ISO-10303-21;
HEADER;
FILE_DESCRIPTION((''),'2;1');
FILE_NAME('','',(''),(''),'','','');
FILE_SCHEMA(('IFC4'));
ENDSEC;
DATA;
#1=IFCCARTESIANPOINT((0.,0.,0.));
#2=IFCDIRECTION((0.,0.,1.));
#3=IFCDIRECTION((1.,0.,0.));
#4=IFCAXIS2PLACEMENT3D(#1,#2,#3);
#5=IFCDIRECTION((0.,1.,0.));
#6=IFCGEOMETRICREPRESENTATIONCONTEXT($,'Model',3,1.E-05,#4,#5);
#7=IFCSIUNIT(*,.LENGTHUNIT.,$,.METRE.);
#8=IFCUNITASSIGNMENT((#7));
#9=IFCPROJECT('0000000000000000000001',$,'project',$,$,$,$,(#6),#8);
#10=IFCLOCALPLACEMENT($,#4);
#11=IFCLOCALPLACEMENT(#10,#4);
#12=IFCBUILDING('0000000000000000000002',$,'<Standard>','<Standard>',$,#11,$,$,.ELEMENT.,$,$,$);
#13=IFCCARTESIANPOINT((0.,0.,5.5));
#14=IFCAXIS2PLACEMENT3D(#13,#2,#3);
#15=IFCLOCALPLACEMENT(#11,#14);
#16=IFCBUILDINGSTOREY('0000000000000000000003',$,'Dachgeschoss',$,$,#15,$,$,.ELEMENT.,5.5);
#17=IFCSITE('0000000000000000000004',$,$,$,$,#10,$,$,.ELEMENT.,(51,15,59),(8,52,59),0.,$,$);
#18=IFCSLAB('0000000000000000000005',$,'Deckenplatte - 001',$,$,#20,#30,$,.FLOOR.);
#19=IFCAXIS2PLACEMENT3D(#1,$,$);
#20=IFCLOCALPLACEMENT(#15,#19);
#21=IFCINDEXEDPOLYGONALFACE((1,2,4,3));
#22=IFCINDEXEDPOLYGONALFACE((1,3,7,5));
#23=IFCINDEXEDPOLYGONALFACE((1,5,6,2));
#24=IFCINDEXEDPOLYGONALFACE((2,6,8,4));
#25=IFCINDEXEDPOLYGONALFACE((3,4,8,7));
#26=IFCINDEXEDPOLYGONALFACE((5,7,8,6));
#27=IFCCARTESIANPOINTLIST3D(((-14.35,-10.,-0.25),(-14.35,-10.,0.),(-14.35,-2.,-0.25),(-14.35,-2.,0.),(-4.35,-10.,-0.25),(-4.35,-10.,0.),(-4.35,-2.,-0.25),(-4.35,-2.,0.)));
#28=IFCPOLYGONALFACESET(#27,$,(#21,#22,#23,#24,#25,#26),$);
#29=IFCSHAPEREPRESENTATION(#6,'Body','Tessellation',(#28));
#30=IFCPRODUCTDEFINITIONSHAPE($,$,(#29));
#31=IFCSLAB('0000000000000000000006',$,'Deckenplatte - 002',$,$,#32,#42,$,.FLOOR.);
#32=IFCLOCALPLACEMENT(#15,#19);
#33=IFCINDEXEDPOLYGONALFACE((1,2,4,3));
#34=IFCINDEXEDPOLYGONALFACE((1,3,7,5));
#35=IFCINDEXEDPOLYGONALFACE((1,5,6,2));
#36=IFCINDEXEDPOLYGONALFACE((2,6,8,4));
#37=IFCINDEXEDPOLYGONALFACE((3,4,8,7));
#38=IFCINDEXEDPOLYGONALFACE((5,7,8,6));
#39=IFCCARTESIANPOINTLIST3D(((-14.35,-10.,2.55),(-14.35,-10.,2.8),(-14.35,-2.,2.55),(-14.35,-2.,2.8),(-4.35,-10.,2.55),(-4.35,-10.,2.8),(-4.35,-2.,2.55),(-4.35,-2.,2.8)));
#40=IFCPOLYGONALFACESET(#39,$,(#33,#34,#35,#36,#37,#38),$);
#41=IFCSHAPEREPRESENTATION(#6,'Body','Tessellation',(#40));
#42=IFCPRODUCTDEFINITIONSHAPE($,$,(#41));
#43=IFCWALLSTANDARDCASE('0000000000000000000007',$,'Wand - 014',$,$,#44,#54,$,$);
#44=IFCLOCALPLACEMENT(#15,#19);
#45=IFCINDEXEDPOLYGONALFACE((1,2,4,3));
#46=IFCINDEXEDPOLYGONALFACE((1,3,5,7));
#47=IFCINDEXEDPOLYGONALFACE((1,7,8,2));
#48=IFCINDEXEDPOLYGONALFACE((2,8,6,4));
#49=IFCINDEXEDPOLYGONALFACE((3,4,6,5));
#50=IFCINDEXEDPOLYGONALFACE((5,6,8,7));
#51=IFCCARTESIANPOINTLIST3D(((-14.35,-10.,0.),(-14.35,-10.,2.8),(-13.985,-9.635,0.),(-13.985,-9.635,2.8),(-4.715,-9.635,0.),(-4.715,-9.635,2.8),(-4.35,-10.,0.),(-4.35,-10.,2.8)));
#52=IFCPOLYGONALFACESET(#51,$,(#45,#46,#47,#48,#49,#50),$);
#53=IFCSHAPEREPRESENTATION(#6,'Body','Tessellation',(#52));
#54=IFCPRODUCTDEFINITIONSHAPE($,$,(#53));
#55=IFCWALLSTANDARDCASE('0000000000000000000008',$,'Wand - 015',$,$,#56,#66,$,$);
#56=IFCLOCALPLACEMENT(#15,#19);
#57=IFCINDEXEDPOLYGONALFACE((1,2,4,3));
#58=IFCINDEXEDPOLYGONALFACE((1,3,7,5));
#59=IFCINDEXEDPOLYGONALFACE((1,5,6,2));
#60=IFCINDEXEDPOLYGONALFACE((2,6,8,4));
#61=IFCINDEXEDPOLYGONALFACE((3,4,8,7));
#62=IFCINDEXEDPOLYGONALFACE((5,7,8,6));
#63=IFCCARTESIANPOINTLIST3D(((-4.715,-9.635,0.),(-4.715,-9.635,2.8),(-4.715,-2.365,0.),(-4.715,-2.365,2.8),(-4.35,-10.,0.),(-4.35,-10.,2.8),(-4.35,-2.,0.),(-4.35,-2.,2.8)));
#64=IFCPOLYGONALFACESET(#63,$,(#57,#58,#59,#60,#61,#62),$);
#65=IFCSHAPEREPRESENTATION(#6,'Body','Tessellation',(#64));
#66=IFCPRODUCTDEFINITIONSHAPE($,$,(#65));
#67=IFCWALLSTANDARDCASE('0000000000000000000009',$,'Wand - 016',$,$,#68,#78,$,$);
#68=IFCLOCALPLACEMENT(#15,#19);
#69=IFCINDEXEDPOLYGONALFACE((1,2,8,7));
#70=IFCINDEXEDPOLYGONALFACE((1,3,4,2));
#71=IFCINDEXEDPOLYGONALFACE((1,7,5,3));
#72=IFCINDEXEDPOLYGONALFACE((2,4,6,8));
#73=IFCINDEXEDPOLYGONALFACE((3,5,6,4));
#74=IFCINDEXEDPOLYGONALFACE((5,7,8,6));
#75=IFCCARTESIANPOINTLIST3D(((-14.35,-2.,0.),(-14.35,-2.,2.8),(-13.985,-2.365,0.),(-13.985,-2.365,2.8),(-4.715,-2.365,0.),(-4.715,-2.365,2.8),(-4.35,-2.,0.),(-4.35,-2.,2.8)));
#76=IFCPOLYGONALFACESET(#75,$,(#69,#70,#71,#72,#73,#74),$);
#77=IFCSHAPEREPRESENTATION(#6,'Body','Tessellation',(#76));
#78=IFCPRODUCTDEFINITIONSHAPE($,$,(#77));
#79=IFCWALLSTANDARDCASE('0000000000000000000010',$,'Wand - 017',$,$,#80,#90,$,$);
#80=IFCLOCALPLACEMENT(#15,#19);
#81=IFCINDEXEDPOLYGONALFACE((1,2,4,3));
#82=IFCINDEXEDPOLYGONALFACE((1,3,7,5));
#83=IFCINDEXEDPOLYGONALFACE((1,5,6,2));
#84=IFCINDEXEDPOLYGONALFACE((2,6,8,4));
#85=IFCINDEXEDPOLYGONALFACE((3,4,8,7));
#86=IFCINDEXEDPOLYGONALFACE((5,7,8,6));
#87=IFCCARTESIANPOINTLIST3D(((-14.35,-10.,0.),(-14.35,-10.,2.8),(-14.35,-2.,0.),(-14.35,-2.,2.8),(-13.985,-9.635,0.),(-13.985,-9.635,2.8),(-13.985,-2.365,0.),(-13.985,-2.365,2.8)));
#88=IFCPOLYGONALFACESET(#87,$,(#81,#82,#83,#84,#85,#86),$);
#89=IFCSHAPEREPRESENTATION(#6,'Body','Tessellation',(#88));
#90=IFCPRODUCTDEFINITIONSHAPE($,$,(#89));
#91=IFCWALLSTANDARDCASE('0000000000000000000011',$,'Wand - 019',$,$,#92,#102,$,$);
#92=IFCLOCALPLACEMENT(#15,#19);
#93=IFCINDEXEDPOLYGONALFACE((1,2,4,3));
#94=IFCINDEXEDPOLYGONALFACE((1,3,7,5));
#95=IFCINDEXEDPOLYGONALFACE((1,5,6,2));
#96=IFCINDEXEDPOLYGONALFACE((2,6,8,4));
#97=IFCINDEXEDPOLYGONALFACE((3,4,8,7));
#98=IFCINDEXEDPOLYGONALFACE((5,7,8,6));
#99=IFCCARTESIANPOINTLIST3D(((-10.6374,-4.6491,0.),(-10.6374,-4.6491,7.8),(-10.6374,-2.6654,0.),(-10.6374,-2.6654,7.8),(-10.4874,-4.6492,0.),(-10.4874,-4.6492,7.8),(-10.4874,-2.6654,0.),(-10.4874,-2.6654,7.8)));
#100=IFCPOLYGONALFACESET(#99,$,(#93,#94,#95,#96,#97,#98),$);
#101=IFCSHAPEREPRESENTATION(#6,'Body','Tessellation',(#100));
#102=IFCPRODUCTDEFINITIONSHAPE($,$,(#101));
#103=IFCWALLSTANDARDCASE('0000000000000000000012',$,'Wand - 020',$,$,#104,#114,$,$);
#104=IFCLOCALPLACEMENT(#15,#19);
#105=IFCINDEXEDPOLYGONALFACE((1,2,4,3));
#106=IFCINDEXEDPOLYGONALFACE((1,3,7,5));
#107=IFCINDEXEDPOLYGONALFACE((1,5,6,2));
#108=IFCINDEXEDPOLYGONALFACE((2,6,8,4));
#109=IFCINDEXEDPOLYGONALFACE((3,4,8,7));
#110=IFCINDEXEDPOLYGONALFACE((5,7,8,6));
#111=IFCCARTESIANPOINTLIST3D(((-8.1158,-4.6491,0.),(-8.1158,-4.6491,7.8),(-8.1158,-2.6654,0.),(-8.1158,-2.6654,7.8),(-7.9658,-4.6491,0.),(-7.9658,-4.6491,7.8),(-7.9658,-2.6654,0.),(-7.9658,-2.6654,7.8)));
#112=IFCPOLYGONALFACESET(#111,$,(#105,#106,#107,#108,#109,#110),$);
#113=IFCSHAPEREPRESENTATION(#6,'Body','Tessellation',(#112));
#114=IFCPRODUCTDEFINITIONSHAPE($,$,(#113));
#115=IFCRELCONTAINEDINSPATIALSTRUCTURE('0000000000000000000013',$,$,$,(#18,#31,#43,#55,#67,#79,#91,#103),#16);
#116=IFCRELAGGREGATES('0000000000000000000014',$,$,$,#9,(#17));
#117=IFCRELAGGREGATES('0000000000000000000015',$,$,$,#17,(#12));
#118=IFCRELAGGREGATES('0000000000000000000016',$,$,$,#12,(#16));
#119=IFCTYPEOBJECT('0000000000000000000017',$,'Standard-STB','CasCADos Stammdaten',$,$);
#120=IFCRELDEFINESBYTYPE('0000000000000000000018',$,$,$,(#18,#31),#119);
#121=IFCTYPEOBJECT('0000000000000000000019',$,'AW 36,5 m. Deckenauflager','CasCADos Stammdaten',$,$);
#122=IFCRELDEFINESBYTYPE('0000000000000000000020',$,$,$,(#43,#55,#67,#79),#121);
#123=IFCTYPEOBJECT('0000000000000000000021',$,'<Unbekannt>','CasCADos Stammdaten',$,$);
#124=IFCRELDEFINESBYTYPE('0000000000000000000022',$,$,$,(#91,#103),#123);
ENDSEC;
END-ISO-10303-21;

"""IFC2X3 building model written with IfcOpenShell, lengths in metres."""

from ifc_helpers import new_model, si_unit, direction, frame, origin_with_axes, place, context, project, spatial, polyline, outline, extrude, type_object, element, save


model = new_model("IFC2X3")

# Units and contexts
model_context = context("Model", 3, precision=1e-05, world=origin_with_axes(), true_north=direction((0.0, 1.0, 0.0)))
ifc_project = project(units=[si_unit("LENGTHUNIT", "METRE")], contexts=[model_context])

# Site, building, storey
site_placement = place(None, origin_with_axes())
site = spatial("IfcSite", under=ifc_project, at=site_placement, CompositionType="ELEMENT", RefLatitude=(51, 15, 59), RefLongitude=(8, 52, 59), RefElevation=0.0)
building_placement = place(site_placement, origin_with_axes())
building = spatial("IfcBuilding", under=site, at=building_placement, Name="<Standard>", Description="<Standard>", CompositionType="ELEMENT")
storey_placement = place(building_placement, frame((0.0, 0.0, 5.5), z_axis=(0.0, 0.0, 1.0), x_axis=(1.0, 0.0, 0.0)))
storey = spatial("IfcBuildingStorey", under=building, at=storey_placement, Name="Dachgeschoss", CompositionType="ELEMENT", Elevation=5.5)

# Slabs
ifc_type_object_1 = type_object("IfcTypeObject", Name="Standard-STB", Description="CasCADos Stammdaten")
for number, where, z_axis, x_axis, name in (
    (1, (-9.35, -6.0, -0.25), (0.0, 0.0, 1.0), (1.0, 0.0, 0.0), "Deckenplatte - 001"),
    (2, (-9.35, -6.0, 2.55), (0.0, 0.0, 1.0), (1.0, 0.0, 0.0), "Deckenplatte - 002"),
):
    element("IfcSlab", number, at=place(storey_placement, frame(where, z_axis=z_axis, x_axis=x_axis)), inside=storey, type_object=ifc_type_object_1, Name=name, PredefinedType="FLOOR", context=model_context, shape_type="SweptSolid", body=[
        extrude(outline(polyline([(-5.0, -4.0), (5.0, -4.0), (5.0, 4.0), (-5.0, 4.0), (-5.0, -4.0)])), origin_with_axes(), (0.0, 0.0, 1.0), 0.25),
    ])

# Walls
ifc_type_object_2 = type_object("IfcTypeObject", Name="AW 36,5 m. Deckenauflager", Description="CasCADos Stammdaten")
wall_1_placement = place(storey_placement, frame((-14.35, -10.0, 0.0), z_axis=(0.0, 0.0, 1.0), x_axis=(1.0, 0.0, 0.0)))
element("IfcWallStandardCase", 3, at=wall_1_placement, inside=storey, type_object=ifc_type_object_2, Name="Wand - 014", context=model_context, shape_type="SweptSolid", body=[
    extrude(outline(polyline([(0.365, 0.365), (0.0, 0.0), (10.0, 0.0), (9.635, 0.365), (0.365, 0.365)])), origin_with_axes(), (0.0, 0.0, 1.0), 2.8),
])
wall_2_placement = place(storey_placement, frame((-4.35, -10.0, 0.0), z_axis=(0.0, 0.0, 1.0), x_axis=(0.0, 1.0, 0.0)))
element("IfcWallStandardCase", 4, at=wall_2_placement, inside=storey, type_object=ifc_type_object_2, Name="Wand - 015", context=model_context, shape_type="SweptSolid", body=[
    extrude(outline(polyline([(0.365, 0.365), (0.0, 0.0), (8.0, 0.0), (7.635, 0.365), (0.365, 0.365)])), origin_with_axes(), (0.0, 0.0, 1.0), 2.8),
])
wall_3_placement = place(storey_placement, frame((-4.35, -2.0, 0.0), z_axis=(0.0, 0.0, 1.0), x_axis=(-1.0, 0.0, 0.0)))
element("IfcWallStandardCase", 5, at=wall_3_placement, inside=storey, type_object=ifc_type_object_2, Name="Wand - 016", context=model_context, shape_type="SweptSolid", body=[
    extrude(outline(polyline([(0.365, 0.365), (0.0, 0.0), (10.0, 0.0), (9.635, 0.365), (0.365, 0.365)])), origin_with_axes(), (0.0, 0.0, 1.0), 2.8),
])
wall_4_placement = place(storey_placement, frame((-14.35, -2.0, 0.0), z_axis=(0.0, 0.0, 1.0), x_axis=(0.0, -1.0, 0.0)))
element("IfcWallStandardCase", 6, at=wall_4_placement, inside=storey, type_object=ifc_type_object_2, Name="Wand - 017", context=model_context, shape_type="SweptSolid", body=[
    extrude(outline(polyline([(0.365, 0.365), (0.0, 0.0), (8.0, 0.0), (7.635, 0.365), (0.365, 0.365)])), origin_with_axes(), (0.0, 0.0, 1.0), 2.8),
])

# Shared definitions
ifc_type_object_3 = type_object("IfcTypeObject", Name="<Unbekannt>", Description="CasCADos Stammdaten")

# Walls
wall_5_placement = place(storey_placement, frame((-10.5624, -2.6654, 0.0), z_axis=(0.0, 0.0, 1.0), x_axis=(0.0, -1.0, 0.0)))
element("IfcWallStandardCase", 7, at=wall_5_placement, inside=storey, type_object=ifc_type_object_3, Name="Wand - 019", context=model_context, shape_type="SweptSolid", body=[
    extrude(outline(polyline([(0.0, 0.075), (0.0, -0.075), (1.9838, -0.075), (1.9838, 0.075), (0.0, 0.075)])), origin_with_axes(), (0.0, 0.0, 1.0), 7.8),
])
wall_6_placement = place(storey_placement, frame((-8.0408, -4.6491, 0.0), z_axis=(0.0, 0.0, 1.0), x_axis=(0.0, 1.0, 0.0)))
element("IfcWallStandardCase", 8, at=wall_6_placement, inside=storey, type_object=ifc_type_object_3, Name="Wand - 020", context=model_context, shape_type="SweptSolid", body=[
    extrude(outline(polyline([(0.0, 0.075), (0.0, -0.075), (1.9838, -0.075), (1.9838, 0.075), (0.0, 0.075)])), origin_with_axes(), (0.0, 0.0, 1.0), 7.8),
])

save(model, "model.ifc")
